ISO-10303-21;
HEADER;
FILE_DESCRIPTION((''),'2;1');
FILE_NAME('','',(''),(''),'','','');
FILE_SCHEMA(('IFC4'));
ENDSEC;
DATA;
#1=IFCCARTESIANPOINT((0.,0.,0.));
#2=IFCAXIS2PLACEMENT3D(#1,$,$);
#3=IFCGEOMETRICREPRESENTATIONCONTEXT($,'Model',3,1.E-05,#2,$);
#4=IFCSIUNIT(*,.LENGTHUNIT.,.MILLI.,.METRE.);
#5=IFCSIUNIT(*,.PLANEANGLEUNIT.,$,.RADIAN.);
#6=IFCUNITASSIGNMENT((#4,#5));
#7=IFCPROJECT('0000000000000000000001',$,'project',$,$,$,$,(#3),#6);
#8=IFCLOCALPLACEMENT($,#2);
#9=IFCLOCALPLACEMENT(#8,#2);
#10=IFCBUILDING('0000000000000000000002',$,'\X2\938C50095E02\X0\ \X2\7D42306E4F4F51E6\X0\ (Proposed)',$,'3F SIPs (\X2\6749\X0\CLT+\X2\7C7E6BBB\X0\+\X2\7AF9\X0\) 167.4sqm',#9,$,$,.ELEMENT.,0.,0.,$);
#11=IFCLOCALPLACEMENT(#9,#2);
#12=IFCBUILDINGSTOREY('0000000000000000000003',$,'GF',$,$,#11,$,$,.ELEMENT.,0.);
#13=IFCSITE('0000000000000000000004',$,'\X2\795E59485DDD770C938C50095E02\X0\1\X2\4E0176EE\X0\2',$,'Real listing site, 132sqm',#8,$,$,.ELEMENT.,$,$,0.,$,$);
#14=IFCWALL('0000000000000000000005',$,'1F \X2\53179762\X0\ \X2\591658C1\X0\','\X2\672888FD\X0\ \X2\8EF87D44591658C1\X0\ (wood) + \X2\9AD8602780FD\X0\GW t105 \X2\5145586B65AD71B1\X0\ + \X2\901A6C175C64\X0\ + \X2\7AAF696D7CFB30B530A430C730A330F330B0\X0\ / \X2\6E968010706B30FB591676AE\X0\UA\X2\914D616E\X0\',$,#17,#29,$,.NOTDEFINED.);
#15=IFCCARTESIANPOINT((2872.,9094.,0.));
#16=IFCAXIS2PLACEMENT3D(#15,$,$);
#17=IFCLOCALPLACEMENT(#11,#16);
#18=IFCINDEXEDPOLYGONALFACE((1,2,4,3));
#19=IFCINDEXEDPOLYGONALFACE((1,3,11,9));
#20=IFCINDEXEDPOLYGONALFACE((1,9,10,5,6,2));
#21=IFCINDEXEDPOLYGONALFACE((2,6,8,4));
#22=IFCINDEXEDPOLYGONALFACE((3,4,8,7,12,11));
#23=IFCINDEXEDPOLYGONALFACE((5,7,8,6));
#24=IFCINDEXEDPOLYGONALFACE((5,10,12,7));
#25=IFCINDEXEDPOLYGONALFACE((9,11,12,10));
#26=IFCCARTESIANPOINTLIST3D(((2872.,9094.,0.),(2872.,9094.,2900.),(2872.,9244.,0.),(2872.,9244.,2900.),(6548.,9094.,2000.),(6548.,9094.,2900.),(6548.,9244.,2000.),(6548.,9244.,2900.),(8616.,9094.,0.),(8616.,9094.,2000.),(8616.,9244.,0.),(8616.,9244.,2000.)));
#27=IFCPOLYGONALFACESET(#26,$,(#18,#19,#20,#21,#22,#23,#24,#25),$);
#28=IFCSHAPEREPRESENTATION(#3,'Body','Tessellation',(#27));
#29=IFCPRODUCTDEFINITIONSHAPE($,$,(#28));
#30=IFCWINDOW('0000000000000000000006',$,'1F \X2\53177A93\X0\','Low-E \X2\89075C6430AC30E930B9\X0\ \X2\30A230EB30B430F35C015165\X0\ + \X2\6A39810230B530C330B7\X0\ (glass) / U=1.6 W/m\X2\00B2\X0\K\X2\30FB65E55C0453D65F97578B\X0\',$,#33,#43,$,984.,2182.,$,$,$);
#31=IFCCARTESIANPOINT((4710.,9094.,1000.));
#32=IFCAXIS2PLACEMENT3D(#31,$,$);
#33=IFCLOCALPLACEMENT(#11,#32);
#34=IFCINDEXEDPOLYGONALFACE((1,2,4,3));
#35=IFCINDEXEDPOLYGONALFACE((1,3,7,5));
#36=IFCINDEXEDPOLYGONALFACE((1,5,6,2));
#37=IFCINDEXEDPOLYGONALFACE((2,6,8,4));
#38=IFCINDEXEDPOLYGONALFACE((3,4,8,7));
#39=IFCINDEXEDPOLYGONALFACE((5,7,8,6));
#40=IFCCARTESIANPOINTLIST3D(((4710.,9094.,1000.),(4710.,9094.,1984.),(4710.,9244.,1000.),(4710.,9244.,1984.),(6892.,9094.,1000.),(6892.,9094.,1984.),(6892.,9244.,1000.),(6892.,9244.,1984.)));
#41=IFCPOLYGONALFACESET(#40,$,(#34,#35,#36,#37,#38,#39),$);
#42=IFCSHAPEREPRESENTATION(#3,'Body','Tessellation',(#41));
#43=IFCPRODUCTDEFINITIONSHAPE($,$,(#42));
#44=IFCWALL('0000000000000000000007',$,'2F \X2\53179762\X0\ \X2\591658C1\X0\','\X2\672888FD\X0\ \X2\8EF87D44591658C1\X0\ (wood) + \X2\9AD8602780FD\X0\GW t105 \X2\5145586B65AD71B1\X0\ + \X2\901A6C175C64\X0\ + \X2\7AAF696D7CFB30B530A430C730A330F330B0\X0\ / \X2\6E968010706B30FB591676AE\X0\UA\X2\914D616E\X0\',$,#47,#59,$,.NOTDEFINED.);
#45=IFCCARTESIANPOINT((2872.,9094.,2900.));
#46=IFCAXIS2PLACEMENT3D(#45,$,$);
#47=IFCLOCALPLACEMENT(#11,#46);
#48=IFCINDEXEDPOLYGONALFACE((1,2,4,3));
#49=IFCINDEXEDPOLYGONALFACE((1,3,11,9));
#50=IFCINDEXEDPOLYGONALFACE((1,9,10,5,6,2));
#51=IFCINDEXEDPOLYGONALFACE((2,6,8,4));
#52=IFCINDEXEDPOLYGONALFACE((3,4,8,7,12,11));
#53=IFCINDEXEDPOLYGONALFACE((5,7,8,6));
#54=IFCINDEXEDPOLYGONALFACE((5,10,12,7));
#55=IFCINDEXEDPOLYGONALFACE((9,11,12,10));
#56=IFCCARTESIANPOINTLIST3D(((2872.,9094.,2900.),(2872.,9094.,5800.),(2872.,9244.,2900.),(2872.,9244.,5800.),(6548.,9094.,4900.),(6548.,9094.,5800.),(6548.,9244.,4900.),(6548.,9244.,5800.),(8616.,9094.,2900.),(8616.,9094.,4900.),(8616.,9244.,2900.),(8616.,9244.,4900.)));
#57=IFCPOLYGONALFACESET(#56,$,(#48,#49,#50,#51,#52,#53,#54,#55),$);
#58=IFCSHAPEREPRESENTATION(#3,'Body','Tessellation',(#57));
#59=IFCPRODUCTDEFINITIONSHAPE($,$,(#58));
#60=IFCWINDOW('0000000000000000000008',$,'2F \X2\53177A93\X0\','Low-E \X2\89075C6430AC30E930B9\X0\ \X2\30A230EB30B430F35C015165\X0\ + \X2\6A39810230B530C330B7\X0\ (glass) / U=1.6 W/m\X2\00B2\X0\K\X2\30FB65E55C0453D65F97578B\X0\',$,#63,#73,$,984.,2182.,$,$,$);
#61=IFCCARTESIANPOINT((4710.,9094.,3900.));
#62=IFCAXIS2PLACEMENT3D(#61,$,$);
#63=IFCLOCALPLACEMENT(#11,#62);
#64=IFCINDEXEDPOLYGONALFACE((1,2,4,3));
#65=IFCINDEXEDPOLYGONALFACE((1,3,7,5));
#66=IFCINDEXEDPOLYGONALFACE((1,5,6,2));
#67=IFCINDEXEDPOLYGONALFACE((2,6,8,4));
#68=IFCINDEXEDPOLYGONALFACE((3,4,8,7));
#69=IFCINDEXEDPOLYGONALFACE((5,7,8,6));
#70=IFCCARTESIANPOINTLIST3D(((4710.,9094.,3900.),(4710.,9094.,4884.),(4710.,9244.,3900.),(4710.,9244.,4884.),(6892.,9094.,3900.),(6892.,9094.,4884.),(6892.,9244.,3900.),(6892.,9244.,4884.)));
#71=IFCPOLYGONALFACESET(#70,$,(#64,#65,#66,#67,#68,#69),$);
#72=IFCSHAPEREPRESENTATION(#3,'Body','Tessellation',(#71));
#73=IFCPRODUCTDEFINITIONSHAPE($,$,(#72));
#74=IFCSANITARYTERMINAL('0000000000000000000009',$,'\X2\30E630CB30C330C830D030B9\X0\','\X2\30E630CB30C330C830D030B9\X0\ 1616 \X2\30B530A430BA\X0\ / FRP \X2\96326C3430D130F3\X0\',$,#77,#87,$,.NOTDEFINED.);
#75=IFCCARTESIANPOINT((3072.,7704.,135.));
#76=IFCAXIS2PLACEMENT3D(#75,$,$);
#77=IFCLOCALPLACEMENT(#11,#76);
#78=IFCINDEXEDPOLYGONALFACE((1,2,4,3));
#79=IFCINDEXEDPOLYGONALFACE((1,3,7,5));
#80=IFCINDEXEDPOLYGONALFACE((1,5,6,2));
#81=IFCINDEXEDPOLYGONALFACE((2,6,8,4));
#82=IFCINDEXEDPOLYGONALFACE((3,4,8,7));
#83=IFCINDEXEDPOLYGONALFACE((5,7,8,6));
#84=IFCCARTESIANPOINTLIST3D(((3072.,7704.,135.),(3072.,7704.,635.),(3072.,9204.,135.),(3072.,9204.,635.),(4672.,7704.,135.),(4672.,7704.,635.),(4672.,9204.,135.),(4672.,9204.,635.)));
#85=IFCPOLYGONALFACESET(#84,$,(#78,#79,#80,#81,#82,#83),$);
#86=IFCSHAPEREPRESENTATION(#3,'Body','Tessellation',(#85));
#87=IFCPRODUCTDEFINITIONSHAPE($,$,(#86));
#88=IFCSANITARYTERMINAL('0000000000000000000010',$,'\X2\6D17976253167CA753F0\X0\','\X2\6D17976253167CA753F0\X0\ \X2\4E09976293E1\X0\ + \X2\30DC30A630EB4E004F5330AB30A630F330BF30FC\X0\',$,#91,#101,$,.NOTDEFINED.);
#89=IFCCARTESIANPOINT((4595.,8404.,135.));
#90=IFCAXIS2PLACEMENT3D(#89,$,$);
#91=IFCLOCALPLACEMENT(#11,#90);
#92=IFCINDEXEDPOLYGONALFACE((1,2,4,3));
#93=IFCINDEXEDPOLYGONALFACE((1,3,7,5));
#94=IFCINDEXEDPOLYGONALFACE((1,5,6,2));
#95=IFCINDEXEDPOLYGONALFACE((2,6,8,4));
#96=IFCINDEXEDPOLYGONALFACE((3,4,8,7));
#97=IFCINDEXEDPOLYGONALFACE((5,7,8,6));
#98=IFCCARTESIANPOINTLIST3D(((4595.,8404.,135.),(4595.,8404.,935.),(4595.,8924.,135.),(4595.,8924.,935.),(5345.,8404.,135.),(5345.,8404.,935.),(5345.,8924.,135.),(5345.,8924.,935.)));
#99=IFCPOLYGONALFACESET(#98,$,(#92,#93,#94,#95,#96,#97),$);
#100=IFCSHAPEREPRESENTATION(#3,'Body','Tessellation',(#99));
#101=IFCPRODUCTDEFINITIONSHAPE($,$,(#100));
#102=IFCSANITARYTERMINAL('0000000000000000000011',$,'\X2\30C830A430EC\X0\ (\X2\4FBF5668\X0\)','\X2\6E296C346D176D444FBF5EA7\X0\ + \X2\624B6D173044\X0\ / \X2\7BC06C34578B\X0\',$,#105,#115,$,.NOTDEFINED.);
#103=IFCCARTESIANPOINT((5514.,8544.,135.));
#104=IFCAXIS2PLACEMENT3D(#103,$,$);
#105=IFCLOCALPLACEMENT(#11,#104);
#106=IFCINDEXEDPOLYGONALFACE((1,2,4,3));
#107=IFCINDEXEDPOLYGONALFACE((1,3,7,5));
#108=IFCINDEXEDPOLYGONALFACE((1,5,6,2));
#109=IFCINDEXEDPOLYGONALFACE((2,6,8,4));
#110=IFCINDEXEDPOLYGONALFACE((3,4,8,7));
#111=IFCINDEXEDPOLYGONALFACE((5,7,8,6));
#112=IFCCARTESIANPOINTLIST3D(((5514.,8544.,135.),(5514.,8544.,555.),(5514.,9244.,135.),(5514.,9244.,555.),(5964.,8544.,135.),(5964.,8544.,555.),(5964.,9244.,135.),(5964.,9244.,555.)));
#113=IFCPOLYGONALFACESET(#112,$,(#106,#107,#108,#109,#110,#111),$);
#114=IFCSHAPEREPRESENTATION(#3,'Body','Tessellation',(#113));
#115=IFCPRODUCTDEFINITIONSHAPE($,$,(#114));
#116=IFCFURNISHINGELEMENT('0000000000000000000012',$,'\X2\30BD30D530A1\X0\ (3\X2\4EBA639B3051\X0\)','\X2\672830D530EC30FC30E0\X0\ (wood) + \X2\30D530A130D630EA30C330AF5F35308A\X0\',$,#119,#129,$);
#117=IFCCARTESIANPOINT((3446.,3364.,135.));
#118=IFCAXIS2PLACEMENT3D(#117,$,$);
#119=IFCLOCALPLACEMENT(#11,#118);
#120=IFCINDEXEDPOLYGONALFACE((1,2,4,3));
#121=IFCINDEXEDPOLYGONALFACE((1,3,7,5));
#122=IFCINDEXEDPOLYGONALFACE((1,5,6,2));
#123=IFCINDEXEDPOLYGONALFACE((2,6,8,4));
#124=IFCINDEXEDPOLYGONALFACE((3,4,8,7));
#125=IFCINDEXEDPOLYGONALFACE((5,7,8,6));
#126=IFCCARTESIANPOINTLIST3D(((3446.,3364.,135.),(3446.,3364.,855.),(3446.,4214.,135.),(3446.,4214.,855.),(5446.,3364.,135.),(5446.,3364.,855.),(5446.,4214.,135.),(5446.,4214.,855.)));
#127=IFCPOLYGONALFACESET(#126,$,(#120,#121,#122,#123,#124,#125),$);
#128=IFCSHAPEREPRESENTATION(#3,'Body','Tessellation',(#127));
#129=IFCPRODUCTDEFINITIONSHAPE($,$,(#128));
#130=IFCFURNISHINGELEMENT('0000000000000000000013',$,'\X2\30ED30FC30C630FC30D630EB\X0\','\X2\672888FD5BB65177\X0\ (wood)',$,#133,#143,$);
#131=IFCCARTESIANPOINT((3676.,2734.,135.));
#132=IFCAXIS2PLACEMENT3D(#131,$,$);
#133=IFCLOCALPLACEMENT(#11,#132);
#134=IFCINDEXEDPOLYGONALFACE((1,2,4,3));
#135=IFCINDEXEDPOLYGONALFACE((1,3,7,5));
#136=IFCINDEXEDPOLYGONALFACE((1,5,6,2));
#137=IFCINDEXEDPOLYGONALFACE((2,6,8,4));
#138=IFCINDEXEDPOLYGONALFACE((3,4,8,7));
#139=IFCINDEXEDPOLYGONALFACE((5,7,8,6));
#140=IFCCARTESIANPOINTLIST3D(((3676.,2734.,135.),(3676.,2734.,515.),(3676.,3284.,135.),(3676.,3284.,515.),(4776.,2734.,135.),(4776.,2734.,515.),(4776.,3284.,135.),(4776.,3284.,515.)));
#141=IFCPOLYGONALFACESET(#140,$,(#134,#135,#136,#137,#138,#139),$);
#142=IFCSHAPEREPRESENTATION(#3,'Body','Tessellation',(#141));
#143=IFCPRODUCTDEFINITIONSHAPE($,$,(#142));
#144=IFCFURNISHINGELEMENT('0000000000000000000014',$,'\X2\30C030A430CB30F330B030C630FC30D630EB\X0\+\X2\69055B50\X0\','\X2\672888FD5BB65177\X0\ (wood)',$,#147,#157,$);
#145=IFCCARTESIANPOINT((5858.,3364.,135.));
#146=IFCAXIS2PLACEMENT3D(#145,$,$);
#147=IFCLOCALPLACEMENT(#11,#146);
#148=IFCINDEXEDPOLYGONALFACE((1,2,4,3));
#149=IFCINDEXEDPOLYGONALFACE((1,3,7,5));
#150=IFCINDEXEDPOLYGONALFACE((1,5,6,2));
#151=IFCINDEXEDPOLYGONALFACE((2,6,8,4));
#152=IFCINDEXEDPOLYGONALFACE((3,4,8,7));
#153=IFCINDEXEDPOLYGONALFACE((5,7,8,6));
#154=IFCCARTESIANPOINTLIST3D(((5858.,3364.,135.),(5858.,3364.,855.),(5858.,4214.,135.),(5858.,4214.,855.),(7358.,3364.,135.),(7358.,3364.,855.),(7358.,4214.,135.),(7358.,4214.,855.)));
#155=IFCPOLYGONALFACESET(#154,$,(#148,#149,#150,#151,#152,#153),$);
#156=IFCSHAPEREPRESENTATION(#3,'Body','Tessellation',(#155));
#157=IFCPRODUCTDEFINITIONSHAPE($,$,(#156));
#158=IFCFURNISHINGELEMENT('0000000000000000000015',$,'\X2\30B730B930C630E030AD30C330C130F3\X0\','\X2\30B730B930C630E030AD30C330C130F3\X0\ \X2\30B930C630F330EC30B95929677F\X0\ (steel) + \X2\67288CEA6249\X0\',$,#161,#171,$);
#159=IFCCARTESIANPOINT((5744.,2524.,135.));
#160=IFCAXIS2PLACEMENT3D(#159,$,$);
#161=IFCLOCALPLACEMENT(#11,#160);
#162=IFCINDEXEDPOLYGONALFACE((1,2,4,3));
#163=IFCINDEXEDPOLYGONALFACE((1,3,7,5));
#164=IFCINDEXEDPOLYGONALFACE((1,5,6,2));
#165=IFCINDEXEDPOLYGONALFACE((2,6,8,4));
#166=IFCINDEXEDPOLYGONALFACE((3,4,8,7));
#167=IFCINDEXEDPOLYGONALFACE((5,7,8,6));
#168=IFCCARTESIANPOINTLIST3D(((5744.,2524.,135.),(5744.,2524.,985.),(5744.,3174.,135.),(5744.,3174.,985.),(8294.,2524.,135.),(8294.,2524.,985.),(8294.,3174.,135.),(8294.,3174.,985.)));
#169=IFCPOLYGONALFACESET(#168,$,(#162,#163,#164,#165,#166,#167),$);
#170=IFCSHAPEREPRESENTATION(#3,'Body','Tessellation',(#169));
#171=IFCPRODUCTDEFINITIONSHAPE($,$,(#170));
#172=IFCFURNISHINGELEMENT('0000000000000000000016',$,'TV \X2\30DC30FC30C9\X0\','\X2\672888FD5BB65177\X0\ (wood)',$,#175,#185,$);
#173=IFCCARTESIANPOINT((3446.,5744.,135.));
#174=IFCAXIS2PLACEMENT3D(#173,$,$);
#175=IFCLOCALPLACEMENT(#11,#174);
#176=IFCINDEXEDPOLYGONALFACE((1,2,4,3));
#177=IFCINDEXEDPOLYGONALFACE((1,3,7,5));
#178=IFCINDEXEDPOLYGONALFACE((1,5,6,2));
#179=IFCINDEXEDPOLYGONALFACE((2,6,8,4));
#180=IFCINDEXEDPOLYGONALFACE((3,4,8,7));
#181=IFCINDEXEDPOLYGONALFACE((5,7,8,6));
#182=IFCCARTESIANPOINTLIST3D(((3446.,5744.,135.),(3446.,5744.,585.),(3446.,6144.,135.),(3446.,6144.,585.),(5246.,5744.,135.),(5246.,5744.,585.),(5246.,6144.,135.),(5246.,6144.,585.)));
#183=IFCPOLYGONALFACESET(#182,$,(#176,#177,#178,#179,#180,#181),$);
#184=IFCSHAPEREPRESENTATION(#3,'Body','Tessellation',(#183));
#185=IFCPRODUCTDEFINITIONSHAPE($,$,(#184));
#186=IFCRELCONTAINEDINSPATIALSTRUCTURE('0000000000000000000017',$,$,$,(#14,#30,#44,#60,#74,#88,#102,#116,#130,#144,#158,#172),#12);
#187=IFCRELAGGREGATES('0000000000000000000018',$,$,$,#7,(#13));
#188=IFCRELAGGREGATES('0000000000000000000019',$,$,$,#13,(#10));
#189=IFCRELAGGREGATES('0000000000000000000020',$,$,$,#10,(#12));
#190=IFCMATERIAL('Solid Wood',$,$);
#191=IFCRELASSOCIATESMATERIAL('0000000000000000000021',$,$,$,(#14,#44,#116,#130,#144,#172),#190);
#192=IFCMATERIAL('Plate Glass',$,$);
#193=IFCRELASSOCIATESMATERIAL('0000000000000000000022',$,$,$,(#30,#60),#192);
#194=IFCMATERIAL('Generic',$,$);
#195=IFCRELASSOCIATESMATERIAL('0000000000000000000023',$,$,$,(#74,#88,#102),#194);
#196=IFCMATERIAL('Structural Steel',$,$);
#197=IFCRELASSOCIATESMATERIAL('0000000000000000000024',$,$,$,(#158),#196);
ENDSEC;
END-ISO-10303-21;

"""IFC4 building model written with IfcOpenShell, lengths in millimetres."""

from ifc_helpers import new_model, si_unit, frame, frame_2d, origin, place, context, project, spatial, rectangle, extrude, material, element, fill, save


model = new_model("IFC4")

# Units and contexts
model_context = context("Model", 3, precision=1e-05, world=origin())
ifc_project = project(units=[si_unit("LENGTHUNIT", "METRE", prefix="MILLI"), si_unit("PLANEANGLEUNIT", "RADIAN")], contexts=[model_context])

# Site, building, storey
site_placement = place(None, origin())
site = spatial("IfcSite", under=ifc_project, at=site_placement, Name="神奈川県鎌倉市1丁目2", ObjectType="Real listing site, 132sqm", CompositionType="ELEMENT", RefElevation=0.0)
building_placement = place(site_placement, origin())
building = spatial("IfcBuilding", under=site, at=building_placement, Name="鎌倉市 終の住処 (Proposed)", ObjectType="3F SIPs (杉CLT+籾殻+竹) 167.4sqm", CompositionType="ELEMENT", ElevationOfRefHeight=0.0, ElevationOfTerrain=0.0)
storey_placement = place(building_placement, origin())
storey = spatial("IfcBuildingStorey", under=building, at=storey_placement, Name="GF", CompositionType="ELEMENT", Elevation=0.0)

# Wall, opening, window
ifc_material_1 = material(Name="Solid Wood")
wall_1_placement = place(storey_placement, frame((2872.0, 9094.0, 0.0)))
wall_1 = element("IfcWall", 1, at=wall_1_placement, inside=storey, material=ifc_material_1, Name="1F 北面 外壁", Description="木製 軸組外壁 (wood) + 高性能GW t105 充填断熱 + 通気層 + 窯業系サイディング / 準耐火・外皮UA配慮", PredefinedType="NOTDEFINED", context=model_context, shape_type="SweptSolid", body=[
    extrude(rectangle(XDim=5744.0, YDim=150.0, at=frame_2d((2872.0, 75.0))), frame((2872.0, 9094.0, 0.0)), (0.0, 0.0, 1.0), 2900.0),
])
opening_1_placement = place(storey_placement, frame((4710.0, 9094.0, 1000.0)))
opening_1 = element("IfcOpeningElement", 2, at=opening_1_placement, cuts=wall_1, PredefinedType="NOTDEFINED", context=model_context, shape_type="SweptSolid", body=[
    extrude(rectangle(XDim=2182.0, YDim=150.0, at=frame_2d((1091.0, 75.0))), frame((4710.0, 9094.0, 1000.0)), (0.0, 0.0, 1.0), 984.0),
])
ifc_material_2 = material(Name="Plate Glass")
window_1_placement = place(storey_placement, frame((4710.0, 9094.0, 1000.0)))
window_1 = element("IfcWindow", 3, at=window_1_placement, inside=storey, material=ifc_material_2, Name="1F 北窓", Description="Low-E 複層ガラス アルゴン封入 + 樹脂サッシ (glass) / U=1.6 W/m²K・日射取得型", OverallHeight=984.0, OverallWidth=2182.0, context=model_context, shape_type="SweptSolid", body=[
    extrude(rectangle(XDim=2182.0, YDim=150.0, at=frame_2d((1091.0, 75.0))), frame((4710.0, 9094.0, 1000.0)), (0.0, 0.0, 1.0), 984.0),
])
fill(opening_1, window_1)

# Wall, opening, window
wall_2_placement = place(storey_placement, frame((2872.0, 9094.0, 2900.0)))
wall_2 = element("IfcWall", 4, at=wall_2_placement, inside=storey, material=ifc_material_1, Name="2F 北面 外壁", Description="木製 軸組外壁 (wood) + 高性能GW t105 充填断熱 + 通気層 + 窯業系サイディング / 準耐火・外皮UA配慮", PredefinedType="NOTDEFINED", context=model_context, shape_type="SweptSolid", body=[
    extrude(rectangle(XDim=5744.0, YDim=150.0, at=frame_2d((2872.0, 75.0))), frame((2872.0, 9094.0, 2900.0)), (0.0, 0.0, 1.0), 2900.0),
])
opening_2_placement = place(storey_placement, frame((4710.0, 9094.0, 3900.0)))
opening_2 = element("IfcOpeningElement", 5, at=opening_2_placement, cuts=wall_2, PredefinedType="NOTDEFINED", context=model_context, shape_type="SweptSolid", body=[
    extrude(rectangle(XDim=2182.0, YDim=150.0, at=frame_2d((1091.0, 75.0))), frame((4710.0, 9094.0, 3900.0)), (0.0, 0.0, 1.0), 984.0),
])
window_2_placement = place(storey_placement, frame((4710.0, 9094.0, 3900.0)))
window_2 = element("IfcWindow", 6, at=window_2_placement, inside=storey, material=ifc_material_2, Name="2F 北窓", Description="Low-E 複層ガラス アルゴン封入 + 樹脂サッシ (glass) / U=1.6 W/m²K・日射取得型", OverallHeight=984.0, OverallWidth=2182.0, context=model_context, shape_type="SweptSolid", body=[
    extrude(rectangle(XDim=2182.0, YDim=150.0, at=frame_2d((1091.0, 75.0))), frame((4710.0, 9094.0, 3900.0)), (0.0, 0.0, 1.0), 984.0),
])
fill(opening_2, window_2)

# Sanitary terminals
ifc_material_3 = material(Name="Generic")
sanitary_terminal_1_placement = place(storey_placement, frame((3072.0, 7704.0, 135.0)))
element("IfcSanitaryTerminal", 7, at=sanitary_terminal_1_placement, inside=storey, material=ifc_material_3, Name="ユニットバス", Description="ユニットバス 1616 サイズ / FRP 防水パン", PredefinedType="NOTDEFINED", context=model_context, shape_type="SweptSolid", body=[
    extrude(rectangle(XDim=1600.0, YDim=1500.0, at=frame_2d((800.0, 750.0))), frame((3072.0, 7704.0, 135.0)), (0.0, 0.0, 1.0), 500.0),
])
sanitary_terminal_2_placement = place(storey_placement, frame((4595.0, 8404.0, 135.0)))
element("IfcSanitaryTerminal", 8, at=sanitary_terminal_2_placement, inside=storey, material=ifc_material_3, Name="洗面化粧台", Description="洗面化粧台 三面鏡 + ボウル一体カウンター", PredefinedType="NOTDEFINED", context=model_context, shape_type="SweptSolid", body=[
    extrude(rectangle(XDim=750.0, YDim=520.0, at=frame_2d((375.0, 260.0))), frame((4595.0, 8404.0, 135.0)), (0.0, 0.0, 1.0), 800.0),
])
sanitary_terminal_3_placement = place(storey_placement, frame((5514.0, 8544.0, 135.0)))
element("IfcSanitaryTerminal", 9, at=sanitary_terminal_3_placement, inside=storey, material=ifc_material_3, Name="トイレ (便器)", Description="温水洗浄便座 + 手洗い / 節水型", PredefinedType="NOTDEFINED", context=model_context, shape_type="SweptSolid", body=[
    extrude(rectangle(XDim=450.0, YDim=700.0, at=frame_2d((225.0, 350.0))), frame((5514.0, 8544.0, 135.0)), (0.0, 0.0, 1.0), 420.0),
])

# Furnishing elements
furnishing_1_placement = place(storey_placement, frame((3446.0, 3364.0, 135.0)))
element("IfcFurnishingElement", 10, at=furnishing_1_placement, inside=storey, material=ifc_material_1, Name="ソファ (3人掛け)", Description="木フレーム (wood) + ファブリック張り", context=model_context, shape_type="SweptSolid", body=[
    extrude(rectangle(XDim=2000.0, YDim=850.0, at=frame_2d((1000.0, 425.0))), frame((3446.0, 3364.0, 135.0)), (0.0, 0.0, 1.0), 720.0),
])
furnishing_2_placement = place(storey_placement, frame((3676.0, 2734.0, 135.0)))
element("IfcFurnishingElement", 11, at=furnishing_2_placement, inside=storey, material=ifc_material_1, Name="ローテーブル", Description="木製家具 (wood)", context=model_context, shape_type="SweptSolid", body=[
    extrude(rectangle(XDim=1100.0, YDim=550.0, at=frame_2d((550.0, 275.0))), frame((3676.0, 2734.0, 135.0)), (0.0, 0.0, 1.0), 380.0),
])
furnishing_3_placement = place(storey_placement, frame((5858.0, 3364.0, 135.0)))
element("IfcFurnishingElement", 12, at=furnishing_3_placement, inside=storey, material=ifc_material_1, Name="ダイニングテーブル+椅子", Description="木製家具 (wood)", context=model_context, shape_type="SweptSolid", body=[
    extrude(rectangle(XDim=1500.0, YDim=850.0, at=frame_2d((750.0, 425.0))), frame((5858.0, 3364.0, 135.0)), (0.0, 0.0, 1.0), 720.0),
])
ifc_material_4 = material(Name="Structural Steel")
furnishing_4_placement = place(storey_placement, frame((5744.0, 2524.0, 135.0)))
element("IfcFurnishingElement", 13, at=furnishing_4_placement, inside=storey, material=ifc_material_4, Name="システムキッチン", Description="システムキッチン ステンレス天板 (steel) + 木質扉", context=model_context, shape_type="SweptSolid", body=[
    extrude(rectangle(XDim=2550.0, YDim=650.0, at=frame_2d((1275.0, 325.0))), frame((5744.0, 2524.0, 135.0)), (0.0, 0.0, 1.0), 850.0),
])
furnishing_5_placement = place(storey_placement, frame((3446.0, 5744.0, 135.0)))
element("IfcFurnishingElement", 14, at=furnishing_5_placement, inside=storey, material=ifc_material_1, Name="TV ボード", Description="木製家具 (wood)", context=model_context, shape_type="SweptSolid", body=[
    extrude(rectangle(XDim=1800.0, YDim=400.0, at=frame_2d((900.0, 200.0))), frame((3446.0, 5744.0, 135.0)), (0.0, 0.0, 1.0), 450.0),
])

save(model, "model.ifc")
